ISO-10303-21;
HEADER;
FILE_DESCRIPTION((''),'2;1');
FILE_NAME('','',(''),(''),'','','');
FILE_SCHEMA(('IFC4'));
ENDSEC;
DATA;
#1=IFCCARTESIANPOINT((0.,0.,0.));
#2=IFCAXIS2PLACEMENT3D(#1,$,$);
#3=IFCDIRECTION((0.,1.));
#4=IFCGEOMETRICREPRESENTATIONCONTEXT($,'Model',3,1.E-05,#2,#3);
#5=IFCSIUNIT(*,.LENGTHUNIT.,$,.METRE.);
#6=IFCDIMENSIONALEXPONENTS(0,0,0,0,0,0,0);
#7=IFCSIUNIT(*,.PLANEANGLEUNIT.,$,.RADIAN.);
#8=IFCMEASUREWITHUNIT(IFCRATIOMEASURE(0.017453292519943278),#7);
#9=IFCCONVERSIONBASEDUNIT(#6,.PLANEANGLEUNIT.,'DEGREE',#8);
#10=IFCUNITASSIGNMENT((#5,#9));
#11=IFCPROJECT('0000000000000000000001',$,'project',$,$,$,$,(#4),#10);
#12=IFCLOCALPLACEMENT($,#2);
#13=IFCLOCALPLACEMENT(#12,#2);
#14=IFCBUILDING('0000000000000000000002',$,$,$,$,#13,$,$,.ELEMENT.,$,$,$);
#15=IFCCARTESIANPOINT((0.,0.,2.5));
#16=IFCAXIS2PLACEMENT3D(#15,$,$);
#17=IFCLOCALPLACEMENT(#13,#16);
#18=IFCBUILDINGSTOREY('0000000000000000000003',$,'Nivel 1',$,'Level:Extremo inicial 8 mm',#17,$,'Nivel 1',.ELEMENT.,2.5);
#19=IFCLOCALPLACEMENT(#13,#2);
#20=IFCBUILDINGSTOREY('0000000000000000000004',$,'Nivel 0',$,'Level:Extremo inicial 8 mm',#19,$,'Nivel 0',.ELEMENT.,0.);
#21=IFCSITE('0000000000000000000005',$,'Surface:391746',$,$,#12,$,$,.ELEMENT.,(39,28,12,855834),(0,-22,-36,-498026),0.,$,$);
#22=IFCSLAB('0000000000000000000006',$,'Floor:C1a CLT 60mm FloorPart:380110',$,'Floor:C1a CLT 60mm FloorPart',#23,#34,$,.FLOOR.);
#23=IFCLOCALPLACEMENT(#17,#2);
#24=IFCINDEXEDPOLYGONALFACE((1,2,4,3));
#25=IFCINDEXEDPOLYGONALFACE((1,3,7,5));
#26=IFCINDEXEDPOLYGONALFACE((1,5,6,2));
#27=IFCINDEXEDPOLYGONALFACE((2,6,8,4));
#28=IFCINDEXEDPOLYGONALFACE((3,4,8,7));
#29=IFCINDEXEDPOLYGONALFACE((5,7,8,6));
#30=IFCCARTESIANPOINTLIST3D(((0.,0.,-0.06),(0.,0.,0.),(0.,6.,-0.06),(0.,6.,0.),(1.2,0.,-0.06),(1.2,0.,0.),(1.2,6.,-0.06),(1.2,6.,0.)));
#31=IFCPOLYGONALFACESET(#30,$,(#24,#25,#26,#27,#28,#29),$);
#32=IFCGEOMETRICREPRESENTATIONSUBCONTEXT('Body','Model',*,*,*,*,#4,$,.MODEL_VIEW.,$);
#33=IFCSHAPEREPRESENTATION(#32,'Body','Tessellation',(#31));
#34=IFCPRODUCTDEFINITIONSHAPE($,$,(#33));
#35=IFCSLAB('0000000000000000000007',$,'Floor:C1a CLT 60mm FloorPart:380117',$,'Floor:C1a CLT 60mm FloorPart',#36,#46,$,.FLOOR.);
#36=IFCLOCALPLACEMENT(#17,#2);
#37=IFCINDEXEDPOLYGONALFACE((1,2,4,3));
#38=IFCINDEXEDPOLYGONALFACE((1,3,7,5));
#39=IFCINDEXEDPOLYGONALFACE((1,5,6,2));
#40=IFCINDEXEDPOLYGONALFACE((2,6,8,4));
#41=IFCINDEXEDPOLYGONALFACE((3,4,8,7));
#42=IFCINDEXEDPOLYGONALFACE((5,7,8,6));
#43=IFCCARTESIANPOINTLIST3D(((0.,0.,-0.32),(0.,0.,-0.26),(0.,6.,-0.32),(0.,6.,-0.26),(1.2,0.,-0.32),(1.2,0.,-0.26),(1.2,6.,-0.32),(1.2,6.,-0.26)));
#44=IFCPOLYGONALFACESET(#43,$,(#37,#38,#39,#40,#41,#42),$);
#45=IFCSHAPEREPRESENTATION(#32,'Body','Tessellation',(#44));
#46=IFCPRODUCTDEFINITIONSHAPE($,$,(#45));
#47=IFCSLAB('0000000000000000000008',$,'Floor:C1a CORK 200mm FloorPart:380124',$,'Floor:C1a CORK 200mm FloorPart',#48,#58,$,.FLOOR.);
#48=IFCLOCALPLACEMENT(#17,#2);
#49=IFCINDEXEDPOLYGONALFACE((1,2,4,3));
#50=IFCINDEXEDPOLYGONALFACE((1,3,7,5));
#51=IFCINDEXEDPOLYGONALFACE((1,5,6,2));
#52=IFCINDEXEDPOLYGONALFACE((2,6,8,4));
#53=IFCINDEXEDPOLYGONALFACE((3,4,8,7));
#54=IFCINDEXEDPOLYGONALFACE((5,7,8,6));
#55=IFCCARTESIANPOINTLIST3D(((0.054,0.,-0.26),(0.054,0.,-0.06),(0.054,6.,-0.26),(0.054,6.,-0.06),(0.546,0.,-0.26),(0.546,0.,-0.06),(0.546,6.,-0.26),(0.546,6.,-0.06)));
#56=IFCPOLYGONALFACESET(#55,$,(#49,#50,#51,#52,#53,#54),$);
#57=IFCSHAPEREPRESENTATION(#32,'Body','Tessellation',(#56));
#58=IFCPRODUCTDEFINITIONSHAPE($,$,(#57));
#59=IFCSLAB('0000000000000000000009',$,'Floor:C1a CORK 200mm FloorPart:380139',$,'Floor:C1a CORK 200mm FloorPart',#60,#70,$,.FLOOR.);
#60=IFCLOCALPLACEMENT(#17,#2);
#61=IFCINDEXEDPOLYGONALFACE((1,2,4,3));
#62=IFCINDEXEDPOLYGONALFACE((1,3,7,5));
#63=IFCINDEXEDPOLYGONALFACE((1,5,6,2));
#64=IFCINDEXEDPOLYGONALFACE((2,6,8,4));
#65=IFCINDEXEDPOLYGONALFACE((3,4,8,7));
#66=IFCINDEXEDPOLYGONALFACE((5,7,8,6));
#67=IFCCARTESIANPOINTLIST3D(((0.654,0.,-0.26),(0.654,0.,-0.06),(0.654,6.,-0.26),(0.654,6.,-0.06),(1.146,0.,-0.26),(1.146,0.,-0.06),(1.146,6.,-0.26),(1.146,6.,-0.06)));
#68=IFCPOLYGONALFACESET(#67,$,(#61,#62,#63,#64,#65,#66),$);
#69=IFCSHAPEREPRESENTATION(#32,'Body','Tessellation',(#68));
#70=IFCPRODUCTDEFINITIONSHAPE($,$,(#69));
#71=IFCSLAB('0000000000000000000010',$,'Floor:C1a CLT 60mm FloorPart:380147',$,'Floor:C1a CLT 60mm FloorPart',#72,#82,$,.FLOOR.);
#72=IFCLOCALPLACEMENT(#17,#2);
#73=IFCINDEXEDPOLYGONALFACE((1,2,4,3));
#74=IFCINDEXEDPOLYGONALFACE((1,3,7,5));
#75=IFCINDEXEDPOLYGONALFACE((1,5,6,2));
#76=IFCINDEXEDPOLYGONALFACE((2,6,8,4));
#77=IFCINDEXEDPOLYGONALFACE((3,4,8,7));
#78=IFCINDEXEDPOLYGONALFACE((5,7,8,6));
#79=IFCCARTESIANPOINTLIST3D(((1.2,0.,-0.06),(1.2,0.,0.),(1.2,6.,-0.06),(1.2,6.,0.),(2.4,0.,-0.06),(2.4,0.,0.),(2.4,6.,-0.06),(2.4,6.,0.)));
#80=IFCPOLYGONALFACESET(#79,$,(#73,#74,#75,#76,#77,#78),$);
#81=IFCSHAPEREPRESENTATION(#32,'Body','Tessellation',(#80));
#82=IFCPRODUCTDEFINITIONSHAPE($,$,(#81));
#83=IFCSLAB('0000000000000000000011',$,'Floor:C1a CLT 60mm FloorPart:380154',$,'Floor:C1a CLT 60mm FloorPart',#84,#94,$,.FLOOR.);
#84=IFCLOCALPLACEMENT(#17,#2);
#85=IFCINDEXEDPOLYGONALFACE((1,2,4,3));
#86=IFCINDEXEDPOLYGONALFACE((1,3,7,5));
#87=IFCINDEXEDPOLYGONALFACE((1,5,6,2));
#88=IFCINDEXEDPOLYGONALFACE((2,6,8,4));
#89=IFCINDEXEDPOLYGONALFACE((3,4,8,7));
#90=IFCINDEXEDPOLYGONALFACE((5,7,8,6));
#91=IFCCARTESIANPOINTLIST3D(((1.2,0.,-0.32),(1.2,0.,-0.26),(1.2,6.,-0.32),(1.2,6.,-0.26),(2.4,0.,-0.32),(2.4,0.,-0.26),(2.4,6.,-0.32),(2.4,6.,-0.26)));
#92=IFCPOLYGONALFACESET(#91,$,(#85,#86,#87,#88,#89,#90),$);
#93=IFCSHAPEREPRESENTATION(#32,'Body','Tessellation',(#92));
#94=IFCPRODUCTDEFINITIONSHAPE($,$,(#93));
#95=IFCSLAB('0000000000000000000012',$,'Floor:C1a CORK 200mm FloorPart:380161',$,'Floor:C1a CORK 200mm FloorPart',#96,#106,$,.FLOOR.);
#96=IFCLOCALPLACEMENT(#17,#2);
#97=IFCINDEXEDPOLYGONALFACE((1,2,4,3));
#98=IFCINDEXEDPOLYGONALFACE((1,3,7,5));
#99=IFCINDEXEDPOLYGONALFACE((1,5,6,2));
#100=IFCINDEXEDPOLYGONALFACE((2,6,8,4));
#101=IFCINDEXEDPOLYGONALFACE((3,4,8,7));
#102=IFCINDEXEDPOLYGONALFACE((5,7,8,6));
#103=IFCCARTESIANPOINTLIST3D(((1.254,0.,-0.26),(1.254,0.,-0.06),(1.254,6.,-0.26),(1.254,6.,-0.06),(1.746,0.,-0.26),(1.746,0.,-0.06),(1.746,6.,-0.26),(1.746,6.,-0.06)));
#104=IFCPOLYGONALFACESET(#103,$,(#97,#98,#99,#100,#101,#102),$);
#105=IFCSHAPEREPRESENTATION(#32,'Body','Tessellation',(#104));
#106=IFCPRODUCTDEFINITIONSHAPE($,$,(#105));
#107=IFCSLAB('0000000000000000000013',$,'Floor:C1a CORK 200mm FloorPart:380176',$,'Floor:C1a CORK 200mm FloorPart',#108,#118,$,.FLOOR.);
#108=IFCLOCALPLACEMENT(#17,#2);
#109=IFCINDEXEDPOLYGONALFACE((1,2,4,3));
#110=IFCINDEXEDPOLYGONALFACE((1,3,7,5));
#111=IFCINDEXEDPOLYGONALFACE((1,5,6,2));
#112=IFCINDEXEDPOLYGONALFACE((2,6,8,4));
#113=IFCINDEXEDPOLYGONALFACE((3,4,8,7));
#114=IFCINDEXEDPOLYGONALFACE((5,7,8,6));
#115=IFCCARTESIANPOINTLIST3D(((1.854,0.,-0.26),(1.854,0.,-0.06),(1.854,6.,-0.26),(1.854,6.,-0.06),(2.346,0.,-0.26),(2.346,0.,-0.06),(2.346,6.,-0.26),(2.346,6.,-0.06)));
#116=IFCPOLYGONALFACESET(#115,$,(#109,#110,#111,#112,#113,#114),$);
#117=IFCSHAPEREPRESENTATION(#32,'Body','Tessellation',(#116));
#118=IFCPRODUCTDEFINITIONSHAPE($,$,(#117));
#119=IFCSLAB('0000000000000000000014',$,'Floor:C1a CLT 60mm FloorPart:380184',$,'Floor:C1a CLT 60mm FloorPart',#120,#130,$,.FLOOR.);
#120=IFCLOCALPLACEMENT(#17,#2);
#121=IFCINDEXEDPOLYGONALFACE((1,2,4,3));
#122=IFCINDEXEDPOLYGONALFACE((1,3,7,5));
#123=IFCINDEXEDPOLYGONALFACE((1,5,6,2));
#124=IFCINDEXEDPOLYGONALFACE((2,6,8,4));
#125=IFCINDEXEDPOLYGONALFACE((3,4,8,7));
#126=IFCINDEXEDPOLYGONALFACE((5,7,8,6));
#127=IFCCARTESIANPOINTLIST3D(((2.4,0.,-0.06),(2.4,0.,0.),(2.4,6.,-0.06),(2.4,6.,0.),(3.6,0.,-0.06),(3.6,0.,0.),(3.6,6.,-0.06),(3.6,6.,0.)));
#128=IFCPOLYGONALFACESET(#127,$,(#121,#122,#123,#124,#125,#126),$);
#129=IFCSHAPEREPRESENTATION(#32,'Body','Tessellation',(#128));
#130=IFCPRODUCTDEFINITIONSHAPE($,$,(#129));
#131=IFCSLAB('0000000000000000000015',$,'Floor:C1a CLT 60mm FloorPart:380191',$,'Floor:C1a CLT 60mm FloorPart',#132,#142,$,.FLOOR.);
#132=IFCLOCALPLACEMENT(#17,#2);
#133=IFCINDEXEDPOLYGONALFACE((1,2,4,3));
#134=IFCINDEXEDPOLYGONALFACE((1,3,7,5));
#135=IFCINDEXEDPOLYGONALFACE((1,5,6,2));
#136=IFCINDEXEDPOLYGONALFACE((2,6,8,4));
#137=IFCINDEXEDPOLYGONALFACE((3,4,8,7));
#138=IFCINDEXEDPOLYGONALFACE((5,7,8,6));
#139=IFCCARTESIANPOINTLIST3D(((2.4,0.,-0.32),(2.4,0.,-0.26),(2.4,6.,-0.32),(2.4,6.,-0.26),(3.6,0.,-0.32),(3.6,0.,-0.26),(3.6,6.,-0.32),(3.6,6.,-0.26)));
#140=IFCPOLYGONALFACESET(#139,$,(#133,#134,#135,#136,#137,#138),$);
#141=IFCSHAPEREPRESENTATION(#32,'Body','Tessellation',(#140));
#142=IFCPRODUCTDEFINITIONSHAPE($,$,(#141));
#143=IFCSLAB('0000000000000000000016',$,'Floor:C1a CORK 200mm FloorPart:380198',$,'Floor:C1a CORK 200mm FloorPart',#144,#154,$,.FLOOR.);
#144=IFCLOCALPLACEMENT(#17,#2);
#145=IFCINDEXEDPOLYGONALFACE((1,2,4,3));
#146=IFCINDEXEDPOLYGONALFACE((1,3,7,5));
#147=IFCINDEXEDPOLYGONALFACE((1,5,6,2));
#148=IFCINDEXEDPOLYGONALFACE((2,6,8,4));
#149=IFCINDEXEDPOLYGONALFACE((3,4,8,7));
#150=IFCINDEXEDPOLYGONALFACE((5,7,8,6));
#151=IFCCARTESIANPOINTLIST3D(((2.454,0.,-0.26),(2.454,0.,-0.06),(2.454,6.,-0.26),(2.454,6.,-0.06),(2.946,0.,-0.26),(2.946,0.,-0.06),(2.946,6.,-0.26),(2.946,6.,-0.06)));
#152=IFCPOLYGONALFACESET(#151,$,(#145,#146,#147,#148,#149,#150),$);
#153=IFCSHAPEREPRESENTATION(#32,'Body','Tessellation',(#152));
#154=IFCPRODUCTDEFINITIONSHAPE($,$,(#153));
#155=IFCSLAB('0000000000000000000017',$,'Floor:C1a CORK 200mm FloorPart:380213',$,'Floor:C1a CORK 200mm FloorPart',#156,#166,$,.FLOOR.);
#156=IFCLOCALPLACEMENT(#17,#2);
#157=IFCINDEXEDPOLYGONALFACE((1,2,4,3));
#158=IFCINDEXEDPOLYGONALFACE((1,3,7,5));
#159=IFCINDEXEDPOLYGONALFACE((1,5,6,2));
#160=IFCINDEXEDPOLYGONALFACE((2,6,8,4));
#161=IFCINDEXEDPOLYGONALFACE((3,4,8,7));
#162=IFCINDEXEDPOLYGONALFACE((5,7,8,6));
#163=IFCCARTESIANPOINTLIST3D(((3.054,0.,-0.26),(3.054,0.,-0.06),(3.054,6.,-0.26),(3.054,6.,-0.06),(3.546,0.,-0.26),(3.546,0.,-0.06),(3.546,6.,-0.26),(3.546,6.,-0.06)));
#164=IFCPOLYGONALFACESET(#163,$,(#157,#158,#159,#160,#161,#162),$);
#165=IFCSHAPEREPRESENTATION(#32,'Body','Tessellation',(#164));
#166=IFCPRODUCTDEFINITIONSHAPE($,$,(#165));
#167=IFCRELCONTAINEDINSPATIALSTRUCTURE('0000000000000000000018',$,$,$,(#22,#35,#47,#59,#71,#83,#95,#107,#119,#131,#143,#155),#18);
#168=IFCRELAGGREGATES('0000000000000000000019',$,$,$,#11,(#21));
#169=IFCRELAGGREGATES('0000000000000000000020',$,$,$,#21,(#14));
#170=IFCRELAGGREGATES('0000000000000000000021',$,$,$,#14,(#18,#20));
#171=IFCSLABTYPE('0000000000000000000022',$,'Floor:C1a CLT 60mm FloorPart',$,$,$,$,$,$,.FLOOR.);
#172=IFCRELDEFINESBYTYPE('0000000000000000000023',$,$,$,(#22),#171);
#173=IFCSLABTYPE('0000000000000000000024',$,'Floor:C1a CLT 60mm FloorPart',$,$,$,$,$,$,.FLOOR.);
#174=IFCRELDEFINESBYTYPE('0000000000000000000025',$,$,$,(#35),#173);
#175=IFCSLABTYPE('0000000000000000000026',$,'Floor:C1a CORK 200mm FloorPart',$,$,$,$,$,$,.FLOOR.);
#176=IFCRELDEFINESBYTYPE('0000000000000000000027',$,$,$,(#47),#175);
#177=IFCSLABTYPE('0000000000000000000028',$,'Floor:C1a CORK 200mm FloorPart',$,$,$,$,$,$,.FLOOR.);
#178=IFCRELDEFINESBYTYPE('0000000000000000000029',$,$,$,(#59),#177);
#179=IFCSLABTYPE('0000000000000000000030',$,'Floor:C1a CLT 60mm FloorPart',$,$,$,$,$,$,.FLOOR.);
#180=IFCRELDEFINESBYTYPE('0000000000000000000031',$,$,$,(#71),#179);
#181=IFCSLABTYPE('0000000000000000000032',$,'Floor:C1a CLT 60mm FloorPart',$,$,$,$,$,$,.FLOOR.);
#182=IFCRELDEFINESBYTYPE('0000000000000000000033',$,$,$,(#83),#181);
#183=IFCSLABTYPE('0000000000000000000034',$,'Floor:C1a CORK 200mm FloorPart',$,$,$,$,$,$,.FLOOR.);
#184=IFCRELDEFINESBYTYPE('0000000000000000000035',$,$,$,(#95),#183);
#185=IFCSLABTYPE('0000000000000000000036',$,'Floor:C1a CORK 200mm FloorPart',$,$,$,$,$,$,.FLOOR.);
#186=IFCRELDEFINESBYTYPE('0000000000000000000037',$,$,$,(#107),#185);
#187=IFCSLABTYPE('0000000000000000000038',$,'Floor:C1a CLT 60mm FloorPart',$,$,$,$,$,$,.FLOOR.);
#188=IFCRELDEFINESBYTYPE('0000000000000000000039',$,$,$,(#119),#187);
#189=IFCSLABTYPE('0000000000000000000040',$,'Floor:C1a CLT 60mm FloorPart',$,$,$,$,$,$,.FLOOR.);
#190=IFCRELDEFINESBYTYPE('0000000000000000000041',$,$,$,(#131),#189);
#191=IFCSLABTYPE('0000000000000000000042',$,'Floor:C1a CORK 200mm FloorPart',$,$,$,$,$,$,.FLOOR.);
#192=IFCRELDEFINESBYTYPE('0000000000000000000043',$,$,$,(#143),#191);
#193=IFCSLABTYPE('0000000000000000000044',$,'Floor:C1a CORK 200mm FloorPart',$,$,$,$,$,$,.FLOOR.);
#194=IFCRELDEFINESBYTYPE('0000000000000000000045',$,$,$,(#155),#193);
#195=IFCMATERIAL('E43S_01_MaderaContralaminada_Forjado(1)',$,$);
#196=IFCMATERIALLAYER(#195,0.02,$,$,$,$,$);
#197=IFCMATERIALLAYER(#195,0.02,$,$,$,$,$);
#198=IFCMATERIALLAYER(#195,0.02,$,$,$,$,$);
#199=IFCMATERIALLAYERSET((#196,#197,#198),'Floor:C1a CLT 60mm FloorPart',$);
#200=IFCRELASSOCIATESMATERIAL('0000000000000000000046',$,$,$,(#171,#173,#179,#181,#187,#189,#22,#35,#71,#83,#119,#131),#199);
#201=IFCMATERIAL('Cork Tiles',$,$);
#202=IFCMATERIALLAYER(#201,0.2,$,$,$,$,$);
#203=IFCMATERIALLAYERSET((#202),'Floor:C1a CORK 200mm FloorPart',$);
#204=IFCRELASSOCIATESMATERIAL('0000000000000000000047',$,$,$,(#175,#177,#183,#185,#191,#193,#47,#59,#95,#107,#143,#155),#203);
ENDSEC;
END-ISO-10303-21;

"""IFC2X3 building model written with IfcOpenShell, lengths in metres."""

from ifc_helpers import new_model, entity, si_unit, converted_unit, direction, frame, frame_2d, origin, origin_2d_with_axis, place, context, subcontext, project, spatial, rectangle, extrude, material, layer, layer_set, layer_usage, type_object, element, save


model = new_model("IFC2X3")

# Units and contexts
model_context = context("Model", 3, precision=1e-05, world=origin(), true_north=direction((0.0, 1.0)))
body_context = subcontext(model_context, "Body", "Model", "MODEL_VIEW")
ifc_project = project(units=[si_unit("LENGTHUNIT", "METRE"), converted_unit("PLANEANGLEUNIT", "DEGREE", entity("IfcRatioMeasure", 0.017453292519943278), si_unit("PLANEANGLEUNIT", "RADIAN"), dimensions=[0, 0, 0, 0, 0, 0, 0])], contexts=[model_context])

# Site, building, storey
site_placement = place(None, origin())
site = spatial("IfcSite", under=ifc_project, at=site_placement, Name="Surface:391746", CompositionType="ELEMENT", RefLatitude=(39, 28, 12, 855834), RefLongitude=(0, -22, -36, -498026), RefElevation=0.0)
building_placement = place(site_placement, origin())
building = spatial("IfcBuilding", under=site, at=building_placement, CompositionType="ELEMENT")
storey_1_placement = place(building_placement, frame((0.0, 0.0, 2.5)))
storey_1 = spatial("IfcBuildingStorey", under=building, at=storey_1_placement, Name="Nivel 1", ObjectType="Level:Extremo inicial 8 mm", LongName="Nivel 1", CompositionType="ELEMENT", Elevation=2.5)

# Shared definitions
ifc_material_1 = material(Name="E43S_01_MaderaContralaminada_Forjado(1)")

# Slabs
ifc_layer_1 = layer(ifc_material_1, 0.02)
ifc_layer_2 = layer(ifc_material_1, 0.02)
ifc_layer_3 = layer(ifc_material_1, 0.02)
ifc_layer_set_1 = layer_set([ifc_layer_1, ifc_layer_2, ifc_layer_3], Name="Floor:C1a CLT 60mm FloorPart")
ifc_layer_usage_1 = layer_usage(ifc_layer_set_1, "AXIS3", "POSITIVE", 0.0)
slab_type_1 = type_object("IfcSlabType", Name="Floor:C1a CLT 60mm FloorPart", PredefinedType="FLOOR", material=ifc_layer_set_1)
slab_1_placement = place(storey_1_placement, origin())
element("IfcSlab", 1, at=slab_1_placement, inside=storey_1, type_object=slab_type_1, material=ifc_layer_usage_1, Name="Floor:C1a CLT 60mm FloorPart:380110", ObjectType="Floor:C1a CLT 60mm FloorPart", PredefinedType="FLOOR", context=body_context, shape_type="SweptSolid", body=[
    extrude(rectangle(XDim=6.0, YDim=1.2, at=origin_2d_with_axis()), frame((0.6, 3.0, 0.0), z_axis=(0.0, 0.0, -1.0), x_axis=(0.0, 1.0, 0.0)), (0.0, 0.0, 1.0), 0.06),
])
ifc_layer_usage_2 = layer_usage(ifc_layer_set_1, "AXIS3", "POSITIVE", 0.0)
slab_type_2 = type_object("IfcSlabType", Name="Floor:C1a CLT 60mm FloorPart", PredefinedType="FLOOR", material=ifc_layer_set_1)
slab_2_placement = place(storey_1_placement, origin())
element("IfcSlab", 2, at=slab_2_placement, inside=storey_1, type_object=slab_type_2, material=ifc_layer_usage_2, Name="Floor:C1a CLT 60mm FloorPart:380117", ObjectType="Floor:C1a CLT 60mm FloorPart", PredefinedType="FLOOR", context=body_context, shape_type="SweptSolid", body=[
    extrude(rectangle(XDim=6.0, YDim=1.2, at=origin_2d_with_axis()), frame((0.6, 3.0, -0.26), z_axis=(0.0, 0.0, -1.0), x_axis=(0.0, 1.0, 0.0)), (0.0, 0.0, 1.0), 0.06),
])
ifc_material_2 = material(Name="Cork Tiles")
ifc_layer_4 = layer(ifc_material_2, 0.2)
ifc_layer_set_2 = layer_set([ifc_layer_4], Name="Floor:C1a CORK 200mm FloorPart")
ifc_layer_usage_3 = layer_usage(ifc_layer_set_2, "AXIS3", "POSITIVE", 0.0)
slab_type_3 = type_object("IfcSlabType", Name="Floor:C1a CORK 200mm FloorPart", PredefinedType="FLOOR", material=ifc_layer_set_2)
slab_3_placement = place(storey_1_placement, origin())
element("IfcSlab", 3, at=slab_3_placement, inside=storey_1, type_object=slab_type_3, material=ifc_layer_usage_3, Name="Floor:C1a CORK 200mm FloorPart:380124", ObjectType="Floor:C1a CORK 200mm FloorPart", PredefinedType="FLOOR", context=body_context, shape_type="SweptSolid", body=[
    extrude(rectangle(XDim=6.0, YDim=0.492, at=origin_2d_with_axis()), frame((0.3, 3.0, -0.06), z_axis=(0.0, 0.0, -1.0), x_axis=(0.0, 1.0, 0.0)), (0.0, 0.0, 1.0), 0.2),
])
ifc_layer_usage_4 = layer_usage(ifc_layer_set_2, "AXIS3", "POSITIVE", 0.0)
slab_type_4 = type_object("IfcSlabType", Name="Floor:C1a CORK 200mm FloorPart", PredefinedType="FLOOR", material=ifc_layer_set_2)
slab_4_placement = place(storey_1_placement, origin())
element("IfcSlab", 4, at=slab_4_placement, inside=storey_1, type_object=slab_type_4, material=ifc_layer_usage_4, Name="Floor:C1a CORK 200mm FloorPart:380139", ObjectType="Floor:C1a CORK 200mm FloorPart", PredefinedType="FLOOR", context=body_context, shape_type="SweptSolid", body=[
    extrude(rectangle(XDim=6.0, YDim=0.492, at=frame_2d((0.0, 0.0), x_axis=(1.0, 0.0))), frame((0.9, 3.0, -0.06), z_axis=(0.0, 0.0, -1.0), x_axis=(0.0, 1.0, 0.0)), (0.0, 0.0, 1.0), 0.2),
])
ifc_layer_usage_5 = layer_usage(ifc_layer_set_1, "AXIS3", "POSITIVE", 0.0)
slab_type_5 = type_object("IfcSlabType", Name="Floor:C1a CLT 60mm FloorPart", PredefinedType="FLOOR", material=ifc_layer_set_1)
slab_5_placement = place(storey_1_placement, origin())
element("IfcSlab", 5, at=slab_5_placement, inside=storey_1, type_object=slab_type_5, material=ifc_layer_usage_5, Name="Floor:C1a CLT 60mm FloorPart:380147", ObjectType="Floor:C1a CLT 60mm FloorPart", PredefinedType="FLOOR", context=body_context, shape_type="SweptSolid", body=[
    extrude(rectangle(XDim=6.0, YDim=1.2, at=origin_2d_with_axis()), frame((1.8, 3.0, 0.0), z_axis=(0.0, 0.0, -1.0), x_axis=(0.0, 1.0, 0.0)), (0.0, 0.0, 1.0), 0.06),
])
ifc_layer_usage_6 = layer_usage(ifc_layer_set_1, "AXIS3", "POSITIVE", 0.0)
slab_type_6 = type_object("IfcSlabType", Name="Floor:C1a CLT 60mm FloorPart", PredefinedType="FLOOR", material=ifc_layer_set_1)
slab_6_placement = place(storey_1_placement, origin())
element("IfcSlab", 6, at=slab_6_placement, inside=storey_1, type_object=slab_type_6, material=ifc_layer_usage_6, Name="Floor:C1a CLT 60mm FloorPart:380154", ObjectType="Floor:C1a CLT 60mm FloorPart", PredefinedType="FLOOR", context=body_context, shape_type="SweptSolid", body=[
    extrude(rectangle(XDim=6.0, YDim=1.2, at=origin_2d_with_axis()), frame((1.8, 3.0, -0.26), z_axis=(0.0, 0.0, -1.0), x_axis=(0.0, 1.0, 0.0)), (0.0, 0.0, 1.0), 0.06),
])
ifc_layer_usage_7 = layer_usage(ifc_layer_set_2, "AXIS3", "POSITIVE", 0.0)
slab_type_7 = type_object("IfcSlabType", Name="Floor:C1a CORK 200mm FloorPart", PredefinedType="FLOOR", material=ifc_layer_set_2)
slab_7_placement = place(storey_1_placement, origin())
element("IfcSlab", 7, at=slab_7_placement, inside=storey_1, type_object=slab_type_7, material=ifc_layer_usage_7, Name="Floor:C1a CORK 200mm FloorPart:380161", ObjectType="Floor:C1a CORK 200mm FloorPart", PredefinedType="FLOOR", context=body_context, shape_type="SweptSolid", body=[
    extrude(rectangle(XDim=6.0, YDim=0.492, at=frame_2d((0.0, 0.0), x_axis=(1.0, 0.0))), frame((1.5, 3.0, -0.06), z_axis=(0.0, 0.0, -1.0), x_axis=(0.0, 1.0, 0.0)), (0.0, 0.0, 1.0), 0.2),
])
ifc_layer_usage_8 = layer_usage(ifc_layer_set_2, "AXIS3", "POSITIVE", 0.0)
slab_type_8 = type_object("IfcSlabType", Name="Floor:C1a CORK 200mm FloorPart", PredefinedType="FLOOR", material=ifc_layer_set_2)
slab_8_placement = place(storey_1_placement, origin())
element("IfcSlab", 8, at=slab_8_placement, inside=storey_1, type_object=slab_type_8, material=ifc_layer_usage_8, Name="Floor:C1a CORK 200mm FloorPart:380176", ObjectType="Floor:C1a CORK 200mm FloorPart", PredefinedType="FLOOR", context=body_context, shape_type="SweptSolid", body=[
    extrude(rectangle(XDim=6.0, YDim=0.492, at=origin_2d_with_axis()), frame((2.1, 3.0, -0.06), z_axis=(0.0, 0.0, -1.0), x_axis=(0.0, 1.0, 0.0)), (0.0, 0.0, 1.0), 0.2),
])
ifc_layer_usage_9 = layer_usage(ifc_layer_set_1, "AXIS3", "POSITIVE", 0.0)
slab_type_9 = type_object("IfcSlabType", Name="Floor:C1a CLT 60mm FloorPart", PredefinedType="FLOOR", material=ifc_layer_set_1)
slab_9_placement = place(storey_1_placement, origin())
element("IfcSlab", 9, at=slab_9_placement, inside=storey_1, type_object=slab_type_9, material=ifc_layer_usage_9, Name="Floor:C1a CLT 60mm FloorPart:380184", ObjectType="Floor:C1a CLT 60mm FloorPart", PredefinedType="FLOOR", context=body_context, shape_type="SweptSolid", body=[
    extrude(rectangle(XDim=6.0, YDim=1.2, at=origin_2d_with_axis()), frame((3.0, 3.0, 0.0), z_axis=(0.0, 0.0, -1.0), x_axis=(0.0, 1.0, 0.0)), (0.0, 0.0, 1.0), 0.06),
])
ifc_layer_usage_10 = layer_usage(ifc_layer_set_1, "AXIS3", "POSITIVE", 0.0)
slab_type_10 = type_object("IfcSlabType", Name="Floor:C1a CLT 60mm FloorPart", PredefinedType="FLOOR", material=ifc_layer_set_1)
slab_10_placement = place(storey_1_placement, origin())
element("IfcSlab", 10, at=slab_10_placement, inside=storey_1, type_object=slab_type_10, material=ifc_layer_usage_10, Name="Floor:C1a CLT 60mm FloorPart:380191", ObjectType="Floor:C1a CLT 60mm FloorPart", PredefinedType="FLOOR", context=body_context, shape_type="SweptSolid", body=[
    extrude(rectangle(XDim=6.0, YDim=1.2, at=origin_2d_with_axis()), frame((3.0, 3.0, -0.26), z_axis=(0.0, 0.0, -1.0), x_axis=(0.0, 1.0, 0.0)), (0.0, 0.0, 1.0), 0.06),
])
ifc_layer_usage_11 = layer_usage(ifc_layer_set_2, "AXIS3", "POSITIVE", 0.0)
slab_type_11 = type_object("IfcSlabType", Name="Floor:C1a CORK 200mm FloorPart", PredefinedType="FLOOR", material=ifc_layer_set_2)
slab_11_placement = place(storey_1_placement, origin())
element("IfcSlab", 11, at=slab_11_placement, inside=storey_1, type_object=slab_type_11, material=ifc_layer_usage_11, Name="Floor:C1a CORK 200mm FloorPart:380198", ObjectType="Floor:C1a CORK 200mm FloorPart", PredefinedType="FLOOR", context=body_context, shape_type="SweptSolid", body=[
    extrude(rectangle(XDim=6.0, YDim=0.492, at=frame_2d((0.0, 0.0), x_axis=(1.0, 0.0))), frame((2.7, 3.0, -0.06), z_axis=(0.0, 0.0, -1.0), x_axis=(0.0, 1.0, 0.0)), (0.0, 0.0, 1.0), 0.2),
])
ifc_layer_usage_12 = layer_usage(ifc_layer_set_2, "AXIS3", "POSITIVE", 0.0)
slab_type_12 = type_object("IfcSlabType", Name="Floor:C1a CORK 200mm FloorPart", PredefinedType="FLOOR", material=ifc_layer_set_2)
slab_12_placement = place(storey_1_placement, origin())
element("IfcSlab", 12, at=slab_12_placement, inside=storey_1, type_object=slab_type_12, material=ifc_layer_usage_12, Name="Floor:C1a CORK 200mm FloorPart:380213", ObjectType="Floor:C1a CORK 200mm FloorPart", PredefinedType="FLOOR", context=body_context, shape_type="SweptSolid", body=[
    extrude(rectangle(XDim=6.0, YDim=0.492, at=frame_2d((0.0, 0.0), x_axis=(1.0, 0.0))), frame((3.3, 3.0, -0.06), z_axis=(0.0, 0.0, -1.0), x_axis=(0.0, 1.0, 0.0)), (0.0, 0.0, 1.0), 0.2),
])

# Shared definitions
storey_2_placement = place(building_placement, origin())
storey_2 = spatial("IfcBuildingStorey", under=building, at=storey_2_placement, Name="Nivel 0", ObjectType="Level:Extremo inicial 8 mm", LongName="Nivel 0", CompositionType="ELEMENT", Elevation=0.0)

save(model, "model.ifc")
